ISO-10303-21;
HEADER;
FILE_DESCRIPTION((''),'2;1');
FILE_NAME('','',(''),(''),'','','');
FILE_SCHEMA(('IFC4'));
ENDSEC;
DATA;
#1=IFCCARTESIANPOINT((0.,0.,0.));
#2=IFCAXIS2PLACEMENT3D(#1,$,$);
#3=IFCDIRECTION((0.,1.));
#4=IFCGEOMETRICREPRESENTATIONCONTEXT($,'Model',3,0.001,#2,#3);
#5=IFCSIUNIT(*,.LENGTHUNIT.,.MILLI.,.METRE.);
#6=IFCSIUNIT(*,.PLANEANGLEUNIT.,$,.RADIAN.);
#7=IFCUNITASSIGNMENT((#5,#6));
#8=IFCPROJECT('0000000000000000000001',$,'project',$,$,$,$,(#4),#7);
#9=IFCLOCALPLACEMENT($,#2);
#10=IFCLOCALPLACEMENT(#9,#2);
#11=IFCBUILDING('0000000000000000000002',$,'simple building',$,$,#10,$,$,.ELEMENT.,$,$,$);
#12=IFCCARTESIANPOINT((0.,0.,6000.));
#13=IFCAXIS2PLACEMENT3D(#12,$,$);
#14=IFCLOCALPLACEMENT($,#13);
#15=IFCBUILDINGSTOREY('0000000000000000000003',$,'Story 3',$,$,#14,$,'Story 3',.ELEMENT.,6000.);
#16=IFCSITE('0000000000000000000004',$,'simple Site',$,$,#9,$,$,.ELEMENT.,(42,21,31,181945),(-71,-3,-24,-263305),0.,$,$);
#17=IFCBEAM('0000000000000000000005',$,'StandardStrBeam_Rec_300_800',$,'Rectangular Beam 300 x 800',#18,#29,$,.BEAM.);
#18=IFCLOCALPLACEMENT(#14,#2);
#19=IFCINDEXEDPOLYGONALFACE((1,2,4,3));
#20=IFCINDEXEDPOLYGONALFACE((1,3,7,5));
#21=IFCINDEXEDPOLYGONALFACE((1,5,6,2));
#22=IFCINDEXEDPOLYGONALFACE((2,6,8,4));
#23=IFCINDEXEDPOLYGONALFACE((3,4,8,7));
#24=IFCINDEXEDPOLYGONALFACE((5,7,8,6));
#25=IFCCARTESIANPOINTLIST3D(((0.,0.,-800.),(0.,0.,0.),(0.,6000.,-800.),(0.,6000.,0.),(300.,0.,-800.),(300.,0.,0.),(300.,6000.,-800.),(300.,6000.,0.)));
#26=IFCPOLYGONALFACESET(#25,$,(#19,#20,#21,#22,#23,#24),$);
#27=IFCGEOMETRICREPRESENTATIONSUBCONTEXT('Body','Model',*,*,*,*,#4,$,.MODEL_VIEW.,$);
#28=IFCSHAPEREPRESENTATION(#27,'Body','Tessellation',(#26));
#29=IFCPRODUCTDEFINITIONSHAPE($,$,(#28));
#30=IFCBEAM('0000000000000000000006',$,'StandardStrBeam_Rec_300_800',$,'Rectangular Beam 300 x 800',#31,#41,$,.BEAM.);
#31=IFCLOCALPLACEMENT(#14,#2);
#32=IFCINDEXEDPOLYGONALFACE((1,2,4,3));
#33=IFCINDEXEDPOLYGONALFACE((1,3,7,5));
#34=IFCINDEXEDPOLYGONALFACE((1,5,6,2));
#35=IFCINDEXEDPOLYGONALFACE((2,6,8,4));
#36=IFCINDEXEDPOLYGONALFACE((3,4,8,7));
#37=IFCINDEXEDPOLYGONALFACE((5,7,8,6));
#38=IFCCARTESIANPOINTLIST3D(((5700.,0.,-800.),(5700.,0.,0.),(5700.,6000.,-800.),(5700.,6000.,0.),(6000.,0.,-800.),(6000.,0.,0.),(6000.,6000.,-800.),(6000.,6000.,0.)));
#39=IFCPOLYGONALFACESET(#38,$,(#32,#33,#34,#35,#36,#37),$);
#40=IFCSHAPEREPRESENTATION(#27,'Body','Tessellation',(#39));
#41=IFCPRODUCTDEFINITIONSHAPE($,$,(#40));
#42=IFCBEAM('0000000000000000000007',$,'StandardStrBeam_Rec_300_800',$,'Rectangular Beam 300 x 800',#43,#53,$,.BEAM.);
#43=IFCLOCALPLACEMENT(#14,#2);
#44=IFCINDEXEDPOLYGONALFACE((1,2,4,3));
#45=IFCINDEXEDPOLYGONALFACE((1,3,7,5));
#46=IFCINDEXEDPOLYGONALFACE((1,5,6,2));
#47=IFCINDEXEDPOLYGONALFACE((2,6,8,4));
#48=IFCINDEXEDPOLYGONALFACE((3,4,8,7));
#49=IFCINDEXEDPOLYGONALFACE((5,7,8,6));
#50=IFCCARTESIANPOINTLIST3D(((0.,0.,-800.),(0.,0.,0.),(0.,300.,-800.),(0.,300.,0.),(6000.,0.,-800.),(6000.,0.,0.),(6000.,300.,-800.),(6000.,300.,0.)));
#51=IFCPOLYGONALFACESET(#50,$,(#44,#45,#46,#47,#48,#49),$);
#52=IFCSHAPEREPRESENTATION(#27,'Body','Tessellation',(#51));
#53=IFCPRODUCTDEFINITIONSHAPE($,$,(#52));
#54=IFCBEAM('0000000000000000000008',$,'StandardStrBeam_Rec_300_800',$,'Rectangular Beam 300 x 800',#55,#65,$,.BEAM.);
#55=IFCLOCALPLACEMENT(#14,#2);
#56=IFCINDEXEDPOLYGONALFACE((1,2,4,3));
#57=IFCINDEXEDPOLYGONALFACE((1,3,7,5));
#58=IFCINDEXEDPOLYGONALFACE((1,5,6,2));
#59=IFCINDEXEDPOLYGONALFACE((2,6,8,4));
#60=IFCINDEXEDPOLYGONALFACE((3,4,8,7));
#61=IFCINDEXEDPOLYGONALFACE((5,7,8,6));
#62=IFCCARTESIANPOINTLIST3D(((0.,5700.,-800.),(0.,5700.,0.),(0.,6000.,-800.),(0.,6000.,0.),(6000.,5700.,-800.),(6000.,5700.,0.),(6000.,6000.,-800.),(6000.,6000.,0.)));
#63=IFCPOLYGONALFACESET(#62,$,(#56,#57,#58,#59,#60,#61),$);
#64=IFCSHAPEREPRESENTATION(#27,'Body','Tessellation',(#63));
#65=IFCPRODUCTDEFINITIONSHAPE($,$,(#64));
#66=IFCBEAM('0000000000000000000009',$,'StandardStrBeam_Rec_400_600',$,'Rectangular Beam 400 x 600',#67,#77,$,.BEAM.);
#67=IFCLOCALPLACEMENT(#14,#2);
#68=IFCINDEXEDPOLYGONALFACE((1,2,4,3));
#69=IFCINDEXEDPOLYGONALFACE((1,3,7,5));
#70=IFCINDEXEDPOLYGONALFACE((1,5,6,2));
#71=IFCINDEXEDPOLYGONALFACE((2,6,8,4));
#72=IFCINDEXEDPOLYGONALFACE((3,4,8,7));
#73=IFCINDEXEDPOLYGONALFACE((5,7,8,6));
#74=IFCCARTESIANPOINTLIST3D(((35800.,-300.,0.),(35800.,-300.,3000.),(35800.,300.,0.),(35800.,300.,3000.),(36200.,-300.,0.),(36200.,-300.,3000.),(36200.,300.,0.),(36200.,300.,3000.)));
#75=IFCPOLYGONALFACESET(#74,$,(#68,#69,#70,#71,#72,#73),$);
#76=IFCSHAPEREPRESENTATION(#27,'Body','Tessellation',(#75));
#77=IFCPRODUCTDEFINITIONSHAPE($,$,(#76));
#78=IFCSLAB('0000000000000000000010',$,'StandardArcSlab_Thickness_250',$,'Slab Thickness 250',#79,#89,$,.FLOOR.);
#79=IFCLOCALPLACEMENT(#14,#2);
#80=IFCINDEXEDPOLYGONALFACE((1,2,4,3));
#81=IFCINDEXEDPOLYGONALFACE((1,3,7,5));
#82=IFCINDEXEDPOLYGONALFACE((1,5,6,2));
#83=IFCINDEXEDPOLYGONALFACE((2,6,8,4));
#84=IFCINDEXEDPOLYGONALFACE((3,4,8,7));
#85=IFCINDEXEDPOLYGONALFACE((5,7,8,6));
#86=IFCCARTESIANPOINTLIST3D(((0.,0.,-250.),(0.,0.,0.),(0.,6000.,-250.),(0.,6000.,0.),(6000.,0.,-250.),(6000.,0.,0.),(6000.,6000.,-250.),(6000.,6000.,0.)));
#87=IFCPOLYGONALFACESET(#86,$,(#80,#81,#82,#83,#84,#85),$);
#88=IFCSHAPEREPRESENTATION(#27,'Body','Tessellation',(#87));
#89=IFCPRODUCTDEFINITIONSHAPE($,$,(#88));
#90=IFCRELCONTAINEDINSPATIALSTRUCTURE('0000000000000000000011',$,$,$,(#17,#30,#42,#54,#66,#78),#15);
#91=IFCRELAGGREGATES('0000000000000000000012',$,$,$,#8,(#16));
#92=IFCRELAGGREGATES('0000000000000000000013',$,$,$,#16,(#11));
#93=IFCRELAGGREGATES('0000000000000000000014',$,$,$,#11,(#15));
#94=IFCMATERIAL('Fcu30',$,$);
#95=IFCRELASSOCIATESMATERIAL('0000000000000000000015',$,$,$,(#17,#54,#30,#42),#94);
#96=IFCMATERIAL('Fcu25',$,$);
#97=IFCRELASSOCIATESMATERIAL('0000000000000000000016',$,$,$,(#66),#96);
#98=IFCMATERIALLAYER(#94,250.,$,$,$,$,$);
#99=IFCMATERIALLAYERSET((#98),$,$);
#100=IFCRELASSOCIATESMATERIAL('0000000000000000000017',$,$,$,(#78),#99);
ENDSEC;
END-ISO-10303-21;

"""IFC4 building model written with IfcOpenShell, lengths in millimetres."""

from ifc_helpers import new_model, si_unit, direction, frame, origin, origin_with_axes, origin_2d_with_axis, place, context, subcontext, project, spatial, polyline, rectangle, outline, extrude, material, layer, layer_set, layer_usage, material_profile, profile_set, profile_usage, element, save


model = new_model("IFC4")

# Units and contexts
model_context = context("Model", 3, precision=0.001, world=origin(), true_north=direction((0.0, 1.0)))
body_context = subcontext(model_context, "Body", "Model", "MODEL_VIEW")
ifc_project = project(units=[si_unit("LENGTHUNIT", "METRE", prefix="MILLI"), si_unit("PLANEANGLEUNIT", "RADIAN")], contexts=[model_context])

# Site, building, storey
site_placement = place(None, origin())
site = spatial("IfcSite", under=ifc_project, at=site_placement, Name="simple Site", CompositionType="ELEMENT", RefLatitude=(42, 21, 31, 181945), RefLongitude=(-71, -3, -24, -263305), RefElevation=0.0)
building_placement = place(site_placement, origin())
building = spatial("IfcBuilding", under=site, at=building_placement, Name="simple building", CompositionType="ELEMENT")
storey_placement = place(None, frame((0.0, 0.0, 6000.0)))
storey = spatial("IfcBuildingStorey", under=building, at=storey_placement, Name="Story 3", LongName="Story 3", CompositionType="ELEMENT", Elevation=6000.0)

# Beams
ifc_material_1 = material(Name="Fcu30")
ifc_material_profile_1 = material_profile(ifc_material_1, rectangle(XDim=300.0, YDim=800.0, at=origin_2d_with_axis()))
ifc_profile_set_1 = profile_set([ifc_material_profile_1])
ifc_profile_usage_1 = profile_usage(ifc_profile_set_1, cardinal=7)
beam_1_placement = place(None, frame((150.0, 0.0, 5600.0), z_axis=(0.0, 1.0, 0.0), x_axis=(1.0, 0.0, 0.0)))
element("IfcBeam", 1, at=beam_1_placement, inside=storey, material=ifc_profile_usage_1, Name="StandardStrBeam_Rec_300_800", ObjectType="Rectangular Beam 300 x 800", PredefinedType="BEAM", context=body_context, shape_type="SweptSolid", body=[
    extrude(rectangle(XDim=300.0, YDim=800.0, at=origin_2d_with_axis()), origin_with_axes(), (0.0, 0.0, 1.0), 6000.0),
])
ifc_profile_usage_2 = profile_usage(ifc_profile_set_1, cardinal=9)
for number, where, z_axis, x_axis, name in (
    (2, (5850.0, 0.0, 5600.0), (0.0, 1.0, 0.0), (1.0, 0.0, 0.0), "StandardStrBeam_Rec_300_800"),
    (3, (0.0, 150.0, 5600.0), (1.0, 0.0, 0.0), (0.0, -1.0, 0.0), "StandardStrBeam_Rec_300_800"),
):
    element("IfcBeam", number, at=place(None, frame(where, z_axis=z_axis, x_axis=x_axis)), inside=storey, material=ifc_profile_usage_2, Name=name, ObjectType="Rectangular Beam 300 x 800", PredefinedType="BEAM", context=body_context, shape_type="SweptSolid", body=[
        extrude(rectangle(XDim=300.0, YDim=800.0, at=origin_2d_with_axis()), origin_with_axes(), (0.0, 0.0, 1.0), 6000.0),
    ])
beam_2_placement = place(None, frame((0.0, 5850.0, 5600.0), z_axis=(1.0, 0.0, 0.0), x_axis=(0.0, -1.0, 0.0)))
element("IfcBeam", 4, at=beam_2_placement, inside=storey, material=ifc_profile_usage_1, Name="StandardStrBeam_Rec_300_800", ObjectType="Rectangular Beam 300 x 800", PredefinedType="BEAM", context=body_context, shape_type="SweptSolid", body=[
    extrude(rectangle(XDim=300.0, YDim=800.0, at=origin_2d_with_axis()), origin_with_axes(), (0.0, 0.0, 1.0), 6000.0),
])
ifc_material_2 = material(Name="Fcu25")
ifc_material_profile_2 = material_profile(ifc_material_2, rectangle(XDim=400.0, YDim=600.0, at=origin_2d_with_axis()))
ifc_profile_set_2 = profile_set([ifc_material_profile_2])
ifc_profile_usage_3 = profile_usage(ifc_profile_set_2, cardinal=5)
beam_3_placement = place(None, frame((36000.0, 0.0, 6000.0), z_axis=(0.0, 0.0, 1.0), x_axis=(1.0, 0.0, 0.0)))
element("IfcBeam", 5, at=beam_3_placement, inside=storey, material=ifc_profile_usage_3, Name="StandardStrBeam_Rec_400_600", ObjectType="Rectangular Beam 400 x 600", PredefinedType="BEAM", context=body_context, shape_type="SweptSolid", body=[
    extrude(rectangle(XDim=400.0, YDim=600.0, at=origin_2d_with_axis()), origin_with_axes(), (0.0, 0.0, 1.0), 3000.0),
])

# Slab
ifc_layer = layer(ifc_material_1, 250.0)
ifc_layer_set = layer_set([ifc_layer])
ifc_layer_usage = layer_usage(ifc_layer_set, "AXIS3", "POSITIVE", -250.0)
slab_placement = place(None, frame((0.0, 0.0, 5750.0), z_axis=(0.0, 0.0, 1.0), x_axis=(1.0, 0.0, 0.0)))
element("IfcSlab", 6, at=slab_placement, inside=storey, material=ifc_layer_usage, Name="StandardArcSlab_Thickness_250", ObjectType="Slab Thickness 250", PredefinedType="FLOOR", context=body_context, shape_type="SweptSolid", body=[
    extrude(outline(polyline([(0.0, 0.0), (6000.0, 0.0), (6000.0, 6000.0), (0.0, 6000.0), (0.0, 0.0)])), origin_with_axes(), (0.0, 0.0, 1.0), 250.0),
])

save(model, "model.ifc")
